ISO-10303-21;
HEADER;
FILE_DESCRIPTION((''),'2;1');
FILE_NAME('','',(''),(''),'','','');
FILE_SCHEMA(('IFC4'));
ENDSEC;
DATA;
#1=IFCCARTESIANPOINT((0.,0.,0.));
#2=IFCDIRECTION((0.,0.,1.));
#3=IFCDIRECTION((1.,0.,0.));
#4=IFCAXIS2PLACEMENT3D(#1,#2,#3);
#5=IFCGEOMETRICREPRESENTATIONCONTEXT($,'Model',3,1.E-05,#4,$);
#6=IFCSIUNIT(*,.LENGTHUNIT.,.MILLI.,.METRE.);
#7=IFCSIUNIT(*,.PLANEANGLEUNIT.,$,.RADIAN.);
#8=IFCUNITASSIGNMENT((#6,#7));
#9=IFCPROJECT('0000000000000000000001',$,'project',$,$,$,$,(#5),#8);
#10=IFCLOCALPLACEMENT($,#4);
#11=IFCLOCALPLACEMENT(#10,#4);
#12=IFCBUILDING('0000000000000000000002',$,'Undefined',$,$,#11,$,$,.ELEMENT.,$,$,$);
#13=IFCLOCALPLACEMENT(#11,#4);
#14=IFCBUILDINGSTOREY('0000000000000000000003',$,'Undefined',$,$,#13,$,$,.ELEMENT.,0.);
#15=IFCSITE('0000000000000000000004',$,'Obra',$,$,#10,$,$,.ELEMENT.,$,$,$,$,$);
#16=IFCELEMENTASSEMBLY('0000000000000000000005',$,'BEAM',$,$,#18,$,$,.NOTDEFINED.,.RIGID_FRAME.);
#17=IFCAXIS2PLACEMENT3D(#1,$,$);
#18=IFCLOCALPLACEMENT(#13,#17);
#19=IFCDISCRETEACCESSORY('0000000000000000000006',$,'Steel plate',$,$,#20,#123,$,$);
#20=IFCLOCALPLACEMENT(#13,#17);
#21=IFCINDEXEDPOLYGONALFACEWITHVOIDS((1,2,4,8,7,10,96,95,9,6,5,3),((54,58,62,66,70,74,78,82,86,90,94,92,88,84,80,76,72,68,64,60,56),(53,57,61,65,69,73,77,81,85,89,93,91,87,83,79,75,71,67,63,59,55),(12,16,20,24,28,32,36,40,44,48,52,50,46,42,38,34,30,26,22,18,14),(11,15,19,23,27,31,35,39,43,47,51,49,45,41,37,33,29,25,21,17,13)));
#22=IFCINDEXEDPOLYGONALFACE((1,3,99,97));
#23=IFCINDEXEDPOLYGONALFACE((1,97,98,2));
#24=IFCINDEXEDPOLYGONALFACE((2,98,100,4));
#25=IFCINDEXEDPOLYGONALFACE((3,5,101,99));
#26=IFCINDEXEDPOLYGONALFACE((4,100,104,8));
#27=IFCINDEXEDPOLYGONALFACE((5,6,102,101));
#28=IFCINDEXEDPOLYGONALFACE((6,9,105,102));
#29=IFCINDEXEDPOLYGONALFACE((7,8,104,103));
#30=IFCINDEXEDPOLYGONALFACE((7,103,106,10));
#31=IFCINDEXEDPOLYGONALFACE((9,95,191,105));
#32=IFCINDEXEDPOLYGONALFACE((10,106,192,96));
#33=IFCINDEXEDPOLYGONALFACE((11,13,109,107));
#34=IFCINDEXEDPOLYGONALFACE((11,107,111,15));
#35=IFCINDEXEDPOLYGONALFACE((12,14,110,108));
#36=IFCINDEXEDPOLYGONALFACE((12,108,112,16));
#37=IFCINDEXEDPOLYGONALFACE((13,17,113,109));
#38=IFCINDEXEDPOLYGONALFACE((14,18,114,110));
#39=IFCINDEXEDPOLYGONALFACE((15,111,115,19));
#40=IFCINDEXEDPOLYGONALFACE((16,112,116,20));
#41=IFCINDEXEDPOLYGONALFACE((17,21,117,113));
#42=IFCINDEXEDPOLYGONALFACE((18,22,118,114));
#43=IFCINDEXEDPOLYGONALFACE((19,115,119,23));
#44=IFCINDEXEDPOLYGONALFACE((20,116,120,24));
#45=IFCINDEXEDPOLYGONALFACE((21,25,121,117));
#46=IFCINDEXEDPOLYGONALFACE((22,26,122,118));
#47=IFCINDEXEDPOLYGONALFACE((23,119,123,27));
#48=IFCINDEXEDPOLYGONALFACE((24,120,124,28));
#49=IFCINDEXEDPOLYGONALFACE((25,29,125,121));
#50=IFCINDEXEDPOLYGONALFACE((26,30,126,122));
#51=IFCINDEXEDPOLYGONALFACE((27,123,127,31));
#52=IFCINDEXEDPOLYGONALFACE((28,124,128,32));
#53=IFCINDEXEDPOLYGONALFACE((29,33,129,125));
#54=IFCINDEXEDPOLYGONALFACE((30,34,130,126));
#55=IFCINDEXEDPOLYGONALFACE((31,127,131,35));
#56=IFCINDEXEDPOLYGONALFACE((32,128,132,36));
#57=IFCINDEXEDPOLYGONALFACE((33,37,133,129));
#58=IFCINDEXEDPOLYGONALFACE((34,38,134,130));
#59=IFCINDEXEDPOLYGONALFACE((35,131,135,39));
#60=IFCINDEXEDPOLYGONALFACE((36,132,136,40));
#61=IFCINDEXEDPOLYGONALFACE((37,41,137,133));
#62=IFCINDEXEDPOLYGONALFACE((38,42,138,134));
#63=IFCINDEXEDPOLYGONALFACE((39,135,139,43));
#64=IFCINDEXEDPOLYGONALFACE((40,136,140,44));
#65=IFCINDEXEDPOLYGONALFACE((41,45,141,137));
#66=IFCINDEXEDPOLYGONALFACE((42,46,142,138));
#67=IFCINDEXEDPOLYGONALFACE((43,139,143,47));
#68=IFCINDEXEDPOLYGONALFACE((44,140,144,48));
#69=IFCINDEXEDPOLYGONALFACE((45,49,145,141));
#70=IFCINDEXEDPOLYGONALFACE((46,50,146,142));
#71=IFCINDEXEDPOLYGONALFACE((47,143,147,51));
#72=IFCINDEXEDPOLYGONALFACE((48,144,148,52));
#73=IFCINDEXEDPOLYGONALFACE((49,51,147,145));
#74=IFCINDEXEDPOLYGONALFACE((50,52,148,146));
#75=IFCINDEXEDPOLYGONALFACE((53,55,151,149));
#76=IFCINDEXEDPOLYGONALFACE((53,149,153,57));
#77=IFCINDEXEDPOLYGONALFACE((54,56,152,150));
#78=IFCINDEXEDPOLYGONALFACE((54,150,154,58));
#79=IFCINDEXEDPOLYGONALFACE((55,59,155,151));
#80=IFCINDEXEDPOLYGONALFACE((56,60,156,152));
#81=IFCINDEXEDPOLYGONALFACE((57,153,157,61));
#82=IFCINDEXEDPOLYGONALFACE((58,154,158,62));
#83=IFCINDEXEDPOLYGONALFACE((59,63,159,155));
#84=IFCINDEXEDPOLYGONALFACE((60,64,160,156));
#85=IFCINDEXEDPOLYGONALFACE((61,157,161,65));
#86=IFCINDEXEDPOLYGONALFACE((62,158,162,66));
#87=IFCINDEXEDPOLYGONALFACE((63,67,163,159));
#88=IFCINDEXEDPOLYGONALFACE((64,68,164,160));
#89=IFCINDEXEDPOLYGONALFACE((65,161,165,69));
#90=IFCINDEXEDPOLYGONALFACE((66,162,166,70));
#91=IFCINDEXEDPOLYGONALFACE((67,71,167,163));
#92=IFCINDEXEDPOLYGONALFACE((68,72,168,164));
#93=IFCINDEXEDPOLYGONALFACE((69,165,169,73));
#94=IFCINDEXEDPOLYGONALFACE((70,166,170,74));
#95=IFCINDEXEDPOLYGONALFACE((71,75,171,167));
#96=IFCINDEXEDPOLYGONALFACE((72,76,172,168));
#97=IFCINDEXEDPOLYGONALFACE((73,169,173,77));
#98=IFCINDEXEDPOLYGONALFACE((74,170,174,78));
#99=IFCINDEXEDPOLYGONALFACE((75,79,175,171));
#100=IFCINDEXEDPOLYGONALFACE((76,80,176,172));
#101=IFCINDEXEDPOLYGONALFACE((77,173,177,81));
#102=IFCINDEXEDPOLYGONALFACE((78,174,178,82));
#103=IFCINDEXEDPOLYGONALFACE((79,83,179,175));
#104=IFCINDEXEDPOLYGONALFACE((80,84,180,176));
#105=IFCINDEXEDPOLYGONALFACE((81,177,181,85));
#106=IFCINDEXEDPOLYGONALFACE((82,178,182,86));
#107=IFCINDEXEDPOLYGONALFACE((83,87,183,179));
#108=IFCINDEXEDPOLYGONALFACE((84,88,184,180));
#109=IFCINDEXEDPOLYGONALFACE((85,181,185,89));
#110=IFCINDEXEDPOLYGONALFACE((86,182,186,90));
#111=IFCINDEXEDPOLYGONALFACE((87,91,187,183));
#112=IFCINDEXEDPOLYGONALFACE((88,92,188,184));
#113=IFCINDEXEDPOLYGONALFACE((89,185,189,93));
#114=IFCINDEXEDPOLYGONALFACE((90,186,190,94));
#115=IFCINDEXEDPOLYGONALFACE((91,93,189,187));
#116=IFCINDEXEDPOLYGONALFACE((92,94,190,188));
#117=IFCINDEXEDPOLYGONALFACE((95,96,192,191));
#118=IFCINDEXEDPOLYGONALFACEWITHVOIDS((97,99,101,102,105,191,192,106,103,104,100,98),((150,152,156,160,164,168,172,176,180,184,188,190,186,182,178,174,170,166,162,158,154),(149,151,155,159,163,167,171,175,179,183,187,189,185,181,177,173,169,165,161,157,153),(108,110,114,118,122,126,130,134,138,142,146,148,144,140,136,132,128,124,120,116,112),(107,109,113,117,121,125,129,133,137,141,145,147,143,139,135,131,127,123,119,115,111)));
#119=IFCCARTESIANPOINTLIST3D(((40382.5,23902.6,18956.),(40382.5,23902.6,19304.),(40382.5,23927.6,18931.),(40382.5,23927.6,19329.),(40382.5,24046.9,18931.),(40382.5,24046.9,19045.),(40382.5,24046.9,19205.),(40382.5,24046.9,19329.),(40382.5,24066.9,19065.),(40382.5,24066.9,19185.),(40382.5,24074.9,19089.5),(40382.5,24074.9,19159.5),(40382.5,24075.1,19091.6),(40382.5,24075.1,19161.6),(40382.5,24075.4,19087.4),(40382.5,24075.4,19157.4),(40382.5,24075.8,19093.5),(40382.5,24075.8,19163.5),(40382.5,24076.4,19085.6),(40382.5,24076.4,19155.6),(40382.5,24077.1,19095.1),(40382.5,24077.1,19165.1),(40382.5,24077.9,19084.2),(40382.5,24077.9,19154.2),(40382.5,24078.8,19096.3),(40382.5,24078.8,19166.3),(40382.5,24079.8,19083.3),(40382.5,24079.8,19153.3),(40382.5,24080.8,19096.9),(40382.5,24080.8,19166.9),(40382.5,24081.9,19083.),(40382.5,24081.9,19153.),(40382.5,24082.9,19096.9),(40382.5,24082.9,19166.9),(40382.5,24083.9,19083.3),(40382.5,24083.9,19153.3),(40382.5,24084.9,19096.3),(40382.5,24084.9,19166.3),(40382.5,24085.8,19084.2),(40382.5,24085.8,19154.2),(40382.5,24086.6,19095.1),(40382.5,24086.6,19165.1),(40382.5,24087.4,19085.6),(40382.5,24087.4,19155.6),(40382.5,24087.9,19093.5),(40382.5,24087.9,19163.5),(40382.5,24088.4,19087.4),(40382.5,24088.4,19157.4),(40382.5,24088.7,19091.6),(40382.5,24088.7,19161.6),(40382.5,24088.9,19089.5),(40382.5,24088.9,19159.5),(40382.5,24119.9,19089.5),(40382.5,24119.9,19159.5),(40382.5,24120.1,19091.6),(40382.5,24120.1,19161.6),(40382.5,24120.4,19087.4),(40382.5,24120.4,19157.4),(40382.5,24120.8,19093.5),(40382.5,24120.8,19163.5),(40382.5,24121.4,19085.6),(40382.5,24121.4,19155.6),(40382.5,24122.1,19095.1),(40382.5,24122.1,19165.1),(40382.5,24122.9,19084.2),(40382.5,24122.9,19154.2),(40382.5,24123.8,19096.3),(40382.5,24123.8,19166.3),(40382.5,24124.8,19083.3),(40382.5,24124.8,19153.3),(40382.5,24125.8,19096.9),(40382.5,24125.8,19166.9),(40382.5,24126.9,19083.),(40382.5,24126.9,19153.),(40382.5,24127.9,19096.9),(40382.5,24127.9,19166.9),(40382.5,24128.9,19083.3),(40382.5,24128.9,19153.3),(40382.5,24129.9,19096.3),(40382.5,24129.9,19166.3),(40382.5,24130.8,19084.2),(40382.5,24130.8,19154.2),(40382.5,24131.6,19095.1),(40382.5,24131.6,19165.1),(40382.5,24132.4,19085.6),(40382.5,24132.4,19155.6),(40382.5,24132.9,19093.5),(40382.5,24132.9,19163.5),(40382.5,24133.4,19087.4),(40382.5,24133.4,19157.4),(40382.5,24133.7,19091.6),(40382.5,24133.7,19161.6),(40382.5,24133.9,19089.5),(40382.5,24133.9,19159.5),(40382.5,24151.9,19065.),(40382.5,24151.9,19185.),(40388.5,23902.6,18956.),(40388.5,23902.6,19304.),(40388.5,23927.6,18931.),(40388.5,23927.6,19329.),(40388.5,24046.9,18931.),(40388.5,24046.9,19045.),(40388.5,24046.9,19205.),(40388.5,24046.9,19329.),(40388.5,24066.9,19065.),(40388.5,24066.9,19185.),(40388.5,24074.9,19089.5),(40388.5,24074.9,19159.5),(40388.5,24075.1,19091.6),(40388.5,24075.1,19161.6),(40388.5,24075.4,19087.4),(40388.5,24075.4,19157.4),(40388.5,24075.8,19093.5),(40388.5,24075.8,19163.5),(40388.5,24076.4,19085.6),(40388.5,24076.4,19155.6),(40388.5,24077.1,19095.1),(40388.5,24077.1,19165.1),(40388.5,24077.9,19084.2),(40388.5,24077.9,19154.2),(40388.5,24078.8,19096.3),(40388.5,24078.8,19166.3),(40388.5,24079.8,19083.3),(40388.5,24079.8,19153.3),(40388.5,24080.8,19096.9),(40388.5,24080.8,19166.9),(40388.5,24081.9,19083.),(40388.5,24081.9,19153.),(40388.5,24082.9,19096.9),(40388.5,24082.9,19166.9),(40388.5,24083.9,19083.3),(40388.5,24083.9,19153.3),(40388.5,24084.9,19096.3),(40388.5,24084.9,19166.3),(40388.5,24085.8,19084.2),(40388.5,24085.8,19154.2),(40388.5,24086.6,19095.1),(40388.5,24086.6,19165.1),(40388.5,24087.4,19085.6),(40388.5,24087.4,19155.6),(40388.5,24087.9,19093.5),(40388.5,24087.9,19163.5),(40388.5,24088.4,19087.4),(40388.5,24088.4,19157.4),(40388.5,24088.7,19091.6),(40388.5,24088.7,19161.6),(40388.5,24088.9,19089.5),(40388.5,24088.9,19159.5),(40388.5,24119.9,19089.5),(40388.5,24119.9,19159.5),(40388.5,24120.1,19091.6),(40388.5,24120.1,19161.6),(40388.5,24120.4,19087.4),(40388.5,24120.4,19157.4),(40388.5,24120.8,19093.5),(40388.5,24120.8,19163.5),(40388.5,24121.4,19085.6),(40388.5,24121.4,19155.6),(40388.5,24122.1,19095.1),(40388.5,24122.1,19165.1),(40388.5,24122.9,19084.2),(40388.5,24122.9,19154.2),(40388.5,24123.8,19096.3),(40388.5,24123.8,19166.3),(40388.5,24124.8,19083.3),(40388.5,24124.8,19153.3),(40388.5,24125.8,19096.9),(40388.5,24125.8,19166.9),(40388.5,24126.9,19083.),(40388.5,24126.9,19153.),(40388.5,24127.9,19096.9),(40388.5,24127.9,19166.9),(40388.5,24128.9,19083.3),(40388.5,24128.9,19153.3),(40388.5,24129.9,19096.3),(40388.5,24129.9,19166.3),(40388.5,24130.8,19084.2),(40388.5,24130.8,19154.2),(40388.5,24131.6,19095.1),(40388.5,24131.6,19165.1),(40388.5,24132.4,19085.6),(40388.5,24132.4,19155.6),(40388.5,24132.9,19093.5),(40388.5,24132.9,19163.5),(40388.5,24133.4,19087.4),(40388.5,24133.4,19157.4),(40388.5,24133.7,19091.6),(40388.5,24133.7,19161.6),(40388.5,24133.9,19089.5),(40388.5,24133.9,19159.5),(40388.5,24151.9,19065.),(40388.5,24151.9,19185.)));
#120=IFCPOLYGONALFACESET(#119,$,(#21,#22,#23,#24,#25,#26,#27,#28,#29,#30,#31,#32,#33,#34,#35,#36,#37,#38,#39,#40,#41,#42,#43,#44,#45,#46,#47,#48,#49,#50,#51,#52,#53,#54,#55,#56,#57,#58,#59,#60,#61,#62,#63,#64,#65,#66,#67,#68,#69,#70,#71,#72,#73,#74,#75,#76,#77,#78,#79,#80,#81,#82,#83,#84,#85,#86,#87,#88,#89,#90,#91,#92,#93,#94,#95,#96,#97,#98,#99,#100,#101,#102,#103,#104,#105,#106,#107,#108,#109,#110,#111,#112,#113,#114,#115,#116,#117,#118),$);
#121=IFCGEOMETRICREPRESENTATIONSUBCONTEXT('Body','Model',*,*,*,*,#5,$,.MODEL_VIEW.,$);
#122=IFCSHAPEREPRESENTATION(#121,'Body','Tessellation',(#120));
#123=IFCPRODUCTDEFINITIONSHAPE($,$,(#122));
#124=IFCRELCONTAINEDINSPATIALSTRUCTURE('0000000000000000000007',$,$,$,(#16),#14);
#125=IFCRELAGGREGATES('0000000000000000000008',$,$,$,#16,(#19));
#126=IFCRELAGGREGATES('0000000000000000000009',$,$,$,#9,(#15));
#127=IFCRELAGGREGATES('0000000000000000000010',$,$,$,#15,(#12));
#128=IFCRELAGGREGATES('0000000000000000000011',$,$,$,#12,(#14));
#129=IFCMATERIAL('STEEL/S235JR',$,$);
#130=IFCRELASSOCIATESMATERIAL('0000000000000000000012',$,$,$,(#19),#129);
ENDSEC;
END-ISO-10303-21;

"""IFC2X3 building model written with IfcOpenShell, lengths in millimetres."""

from ifc_helpers import new_model, si_unit, frame, origin_with_axes, origin_2d_with_axis, place, context, subcontext, project, spatial, polyline, circle, outline, extrude, source, transform, mapped, material, element, aggregate, save


model = new_model("IFC2X3")

# Units and contexts
model_context = context("Model", 3, precision=1e-05, world=origin_with_axes())
body_context = subcontext(model_context, "Body", "Model", "MODEL_VIEW")
ifc_project = project(units=[si_unit("LENGTHUNIT", "METRE", prefix="MILLI"), si_unit("PLANEANGLEUNIT", "RADIAN")], contexts=[model_context])

# Site, building, storey
site_placement = place(None, origin_with_axes())
site = spatial("IfcSite", under=ifc_project, at=site_placement, Name="Obra", CompositionType="ELEMENT")
building_placement = place(site_placement, origin_with_axes())
building = spatial("IfcBuilding", under=site, at=building_placement, Name="Undefined", CompositionType="ELEMENT")
storey_placement = place(building_placement, origin_with_axes())
storey = spatial("IfcBuildingStorey", under=building, at=storey_placement, Name="Undefined", CompositionType="ELEMENT", Elevation=0.0)

# Shared definitions
ifc_material_1 = material(Name="STEEL/S235JR")

# Element assembly, discrete accessory, opening
assembly_1_placement = place(storey_placement, origin_with_axes())
assembly_1 = element("IfcElementAssembly", 1, at=assembly_1_placement, inside=storey, Name="BEAM", AssemblyPlace="NOTDEFINED", PredefinedType="RIGID_FRAME")
discrete_accessory_1_placement = place(assembly_1_placement, frame((40385.5, 23902.6, 18956.0), z_axis=(1.0, 0.0, 0.0), x_axis=(0.0, 0.707107, -0.707107)))
discrete_accessory_1 = element("IfcDiscreteAccessory", 2, at=discrete_accessory_1_placement, material=ifc_material_1, Name="Steel plate", context=body_context, shape_type="SweptSolid", body=[
    extrude(outline(polyline([(0.0, 0.0), (35.4, 0.0), (119.7, 84.3), (39.1, 164.9), (39.1, 193.2), (99.2, 253.3), (14.3, 338.2), (-45.8, 278.1), (-74.1, 278.1), (-161.8, 365.8), (-246.1, 281.4), (-246.1, 246.1), (0.0, 0.0)])), frame((0.0, 0.0, -3.0), z_axis=(0.0, 0.0, 1.0), x_axis=(1.0, 0.0, 0.0)), (0.0, 0.0, 1.0), 6.0),
])
shared_shape_1 = source(origin_with_axes(), body_context, "Body", "SweptSolid", [
    extrude(circle(Radius=7.0, at=origin_2d_with_axis()), frame((0.0, -8.6, 0.0), z_axis=(0.0, 1.0, 0.0), x_axis=(1.0, 0.0, 0.0)), (0.0, 0.0, 1.0), 6.2),
])
opening_1_placement = place(assembly_1_placement, frame((40380.0, 24056.9, 19185.0), z_axis=(0.0, 1.0, 0.0), x_axis=(0.0, 0.0, -1.0)))
element("IfcOpeningElement", 3, at=opening_1_placement, cuts=discrete_accessory_1, ObjectType="Opening", context=body_context, shape_type="MappedRepresentation", body=[
    mapped(shared_shape_1, transform((25.0, 0.0, 25.0))),
    mapped(shared_shape_1, transform((25.0, 0.0, 70.0))),
    mapped(shared_shape_1, transform((95.0, 0.0, 25.0))),
    mapped(shared_shape_1, transform((95.0, 0.0, 70.0))),
])
aggregate(assembly_1, [discrete_accessory_1])

save(model, "model.ifc")
